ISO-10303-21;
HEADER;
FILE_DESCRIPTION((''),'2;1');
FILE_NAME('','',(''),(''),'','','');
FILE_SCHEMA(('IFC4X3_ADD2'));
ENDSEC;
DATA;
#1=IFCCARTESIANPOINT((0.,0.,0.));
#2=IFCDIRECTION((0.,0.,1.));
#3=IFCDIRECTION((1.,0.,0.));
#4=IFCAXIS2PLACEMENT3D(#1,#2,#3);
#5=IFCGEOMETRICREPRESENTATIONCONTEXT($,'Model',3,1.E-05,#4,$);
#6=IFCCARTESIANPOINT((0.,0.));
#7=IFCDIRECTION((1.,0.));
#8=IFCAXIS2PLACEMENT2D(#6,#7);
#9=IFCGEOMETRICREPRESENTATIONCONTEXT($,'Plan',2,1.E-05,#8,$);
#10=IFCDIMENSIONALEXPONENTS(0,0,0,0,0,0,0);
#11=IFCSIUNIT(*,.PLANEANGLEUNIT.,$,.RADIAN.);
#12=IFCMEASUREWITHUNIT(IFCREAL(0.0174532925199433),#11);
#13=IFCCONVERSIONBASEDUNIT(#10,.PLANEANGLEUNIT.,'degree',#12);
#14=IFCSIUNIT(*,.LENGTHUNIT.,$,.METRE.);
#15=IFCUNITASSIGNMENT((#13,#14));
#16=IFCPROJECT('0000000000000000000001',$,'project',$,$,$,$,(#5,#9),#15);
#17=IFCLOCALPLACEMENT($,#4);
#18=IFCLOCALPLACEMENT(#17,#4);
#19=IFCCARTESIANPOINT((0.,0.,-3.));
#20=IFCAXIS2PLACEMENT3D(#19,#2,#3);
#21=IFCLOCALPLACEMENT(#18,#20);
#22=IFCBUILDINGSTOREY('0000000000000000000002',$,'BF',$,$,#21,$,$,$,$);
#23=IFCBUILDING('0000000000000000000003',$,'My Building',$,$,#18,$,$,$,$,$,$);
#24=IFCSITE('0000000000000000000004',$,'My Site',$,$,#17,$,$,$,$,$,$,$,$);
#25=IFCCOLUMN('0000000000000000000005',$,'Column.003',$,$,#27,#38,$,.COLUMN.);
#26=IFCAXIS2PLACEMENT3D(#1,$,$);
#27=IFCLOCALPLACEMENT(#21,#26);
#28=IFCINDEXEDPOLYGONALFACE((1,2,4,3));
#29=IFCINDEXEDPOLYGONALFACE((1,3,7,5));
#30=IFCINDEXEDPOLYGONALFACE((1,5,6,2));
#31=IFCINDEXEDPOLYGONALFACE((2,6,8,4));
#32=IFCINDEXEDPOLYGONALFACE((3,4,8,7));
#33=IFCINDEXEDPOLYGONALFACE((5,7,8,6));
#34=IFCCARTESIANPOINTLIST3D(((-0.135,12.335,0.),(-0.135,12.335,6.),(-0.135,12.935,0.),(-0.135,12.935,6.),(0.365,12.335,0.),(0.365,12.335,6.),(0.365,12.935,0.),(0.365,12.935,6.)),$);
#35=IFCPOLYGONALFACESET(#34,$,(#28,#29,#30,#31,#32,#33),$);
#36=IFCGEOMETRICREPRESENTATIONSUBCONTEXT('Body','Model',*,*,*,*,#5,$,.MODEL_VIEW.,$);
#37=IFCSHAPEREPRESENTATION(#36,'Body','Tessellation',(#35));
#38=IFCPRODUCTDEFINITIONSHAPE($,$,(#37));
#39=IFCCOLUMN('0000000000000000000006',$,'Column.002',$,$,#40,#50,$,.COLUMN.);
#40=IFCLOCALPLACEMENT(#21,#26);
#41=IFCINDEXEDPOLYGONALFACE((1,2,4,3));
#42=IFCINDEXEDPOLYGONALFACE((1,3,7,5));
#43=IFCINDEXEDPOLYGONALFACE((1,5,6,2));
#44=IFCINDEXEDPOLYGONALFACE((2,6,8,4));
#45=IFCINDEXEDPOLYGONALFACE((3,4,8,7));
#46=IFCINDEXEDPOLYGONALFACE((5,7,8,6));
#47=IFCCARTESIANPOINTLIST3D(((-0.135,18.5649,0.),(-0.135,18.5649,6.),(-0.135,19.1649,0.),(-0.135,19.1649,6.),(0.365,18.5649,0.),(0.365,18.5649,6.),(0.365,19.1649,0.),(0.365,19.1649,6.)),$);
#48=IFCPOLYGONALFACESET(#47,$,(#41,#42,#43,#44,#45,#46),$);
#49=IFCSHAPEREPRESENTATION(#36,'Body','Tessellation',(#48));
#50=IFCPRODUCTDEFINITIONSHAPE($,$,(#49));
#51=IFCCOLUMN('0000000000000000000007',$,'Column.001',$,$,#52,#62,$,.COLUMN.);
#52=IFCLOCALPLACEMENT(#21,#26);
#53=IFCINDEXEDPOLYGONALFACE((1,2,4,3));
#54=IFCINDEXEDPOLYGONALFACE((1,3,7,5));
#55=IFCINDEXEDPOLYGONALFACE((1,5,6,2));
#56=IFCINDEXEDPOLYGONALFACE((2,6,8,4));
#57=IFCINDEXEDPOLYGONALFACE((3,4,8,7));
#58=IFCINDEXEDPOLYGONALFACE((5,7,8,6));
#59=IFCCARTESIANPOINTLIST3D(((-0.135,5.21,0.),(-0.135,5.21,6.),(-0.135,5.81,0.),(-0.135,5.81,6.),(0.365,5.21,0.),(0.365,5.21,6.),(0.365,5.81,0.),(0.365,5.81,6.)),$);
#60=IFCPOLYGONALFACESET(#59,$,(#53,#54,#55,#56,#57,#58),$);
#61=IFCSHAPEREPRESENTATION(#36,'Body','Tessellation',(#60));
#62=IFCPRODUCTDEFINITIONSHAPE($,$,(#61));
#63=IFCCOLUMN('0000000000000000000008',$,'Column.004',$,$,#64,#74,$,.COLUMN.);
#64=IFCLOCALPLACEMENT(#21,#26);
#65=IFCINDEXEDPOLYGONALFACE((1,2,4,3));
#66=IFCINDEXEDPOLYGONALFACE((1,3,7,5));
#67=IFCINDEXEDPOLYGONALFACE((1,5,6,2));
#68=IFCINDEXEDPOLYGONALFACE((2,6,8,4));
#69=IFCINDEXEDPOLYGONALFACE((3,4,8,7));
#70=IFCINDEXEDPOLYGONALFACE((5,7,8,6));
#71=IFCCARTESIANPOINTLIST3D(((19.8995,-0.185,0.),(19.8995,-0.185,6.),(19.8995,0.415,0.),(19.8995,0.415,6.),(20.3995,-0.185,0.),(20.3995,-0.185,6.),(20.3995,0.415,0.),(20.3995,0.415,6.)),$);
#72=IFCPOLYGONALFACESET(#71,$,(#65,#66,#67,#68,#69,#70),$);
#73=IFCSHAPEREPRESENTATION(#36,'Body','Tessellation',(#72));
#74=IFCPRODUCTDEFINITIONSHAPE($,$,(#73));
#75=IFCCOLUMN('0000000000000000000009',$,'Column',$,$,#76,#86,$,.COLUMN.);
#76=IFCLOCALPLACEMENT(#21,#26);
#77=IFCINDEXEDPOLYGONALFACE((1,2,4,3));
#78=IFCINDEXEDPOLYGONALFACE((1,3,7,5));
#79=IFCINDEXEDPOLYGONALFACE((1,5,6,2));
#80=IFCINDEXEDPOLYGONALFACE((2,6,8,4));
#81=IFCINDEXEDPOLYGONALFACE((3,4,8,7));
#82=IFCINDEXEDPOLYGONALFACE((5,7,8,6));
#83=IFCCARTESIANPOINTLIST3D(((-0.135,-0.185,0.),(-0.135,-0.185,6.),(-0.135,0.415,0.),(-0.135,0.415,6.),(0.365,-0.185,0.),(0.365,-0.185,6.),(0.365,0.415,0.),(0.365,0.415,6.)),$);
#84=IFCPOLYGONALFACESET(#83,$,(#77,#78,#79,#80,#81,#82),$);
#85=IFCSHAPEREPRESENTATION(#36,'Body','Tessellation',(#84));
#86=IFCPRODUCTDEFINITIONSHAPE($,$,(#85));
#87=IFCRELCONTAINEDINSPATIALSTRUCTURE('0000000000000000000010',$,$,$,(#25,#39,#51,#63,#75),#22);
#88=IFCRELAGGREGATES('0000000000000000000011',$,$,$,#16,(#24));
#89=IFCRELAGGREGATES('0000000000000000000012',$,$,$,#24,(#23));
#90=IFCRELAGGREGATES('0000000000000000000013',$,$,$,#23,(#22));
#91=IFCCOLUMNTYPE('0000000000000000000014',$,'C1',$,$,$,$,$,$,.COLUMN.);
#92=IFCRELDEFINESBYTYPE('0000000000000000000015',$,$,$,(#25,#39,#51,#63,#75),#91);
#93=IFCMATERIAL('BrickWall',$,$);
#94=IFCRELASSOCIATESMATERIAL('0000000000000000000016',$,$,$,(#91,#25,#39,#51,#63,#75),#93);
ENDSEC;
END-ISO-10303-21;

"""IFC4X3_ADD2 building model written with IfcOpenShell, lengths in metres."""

from ifc_helpers import new_model, entity, si_unit, converted_unit, frame, origin_with_axes, origin_2d_with_axis, place, context, subcontext, project, spatial, rectangle, extrude, material, material_profile, profile_set, profile_usage, type_object, element, save


model = new_model("IFC4X3_ADD2")

# Units and contexts
model_context = context("Model", 3, precision=1e-05, world=origin_with_axes())
plan_context = context("Plan", 2, precision=1e-05, world=origin_2d_with_axis())
body_context = subcontext(model_context, "Body", "Model", "MODEL_VIEW")
ifc_project = project(units=[converted_unit("PLANEANGLEUNIT", "degree", entity("IfcReal", 0.0174532925199433), si_unit("PLANEANGLEUNIT", "RADIAN"), dimensions=[0, 0, 0, 0, 0, 0, 0]), si_unit("LENGTHUNIT", "METRE")], contexts=[model_context, plan_context])

# Site, building, storey
site_placement = place(None, origin_with_axes())
site = spatial("IfcSite", under=ifc_project, at=site_placement, Name="My Site")
building_placement = place(site_placement, origin_with_axes())
building = spatial("IfcBuilding", under=site, at=building_placement, Name="My Building")
storey_placement = place(building_placement, frame((0.0, 0.0, -3.0), z_axis=(0.0, 0.0, 1.0), x_axis=(1.0, 0.0, 0.0)))
storey = spatial("IfcBuildingStorey", under=building, at=storey_placement, Name="BF")

# Columns
ifc_material = material(Name="BrickWall")
ifc_material_profile = material_profile(ifc_material, rectangle(XDim=0.5, YDim=0.6))
ifc_profile_set = profile_set([ifc_material_profile])
ifc_profile_usage_1 = profile_usage(ifc_profile_set, cardinal=5)
column_type = type_object("IfcColumnType", Name="C1", PredefinedType="COLUMN", material=ifc_profile_set)
column_1_placement = place(storey_placement, frame((0.115, 12.635, 0.0), z_axis=(0.0, 0.0, 1.0), x_axis=(1.0, 0.0, 0.0)))
element("IfcColumn", 1, at=column_1_placement, inside=storey, type_object=column_type, material=ifc_profile_usage_1, Name="Column.003", PredefinedType="COLUMN", context=body_context, shape_type="SweptSolid", body=[
    extrude(rectangle(XDim=0.5, YDim=0.6), origin_with_axes(), (0.0, 0.0, 1.0), 6.0),
])
ifc_profile_usage_2 = profile_usage(ifc_profile_set, cardinal=5)
column_2_placement = place(storey_placement, frame((0.115, 18.8649, 0.0), z_axis=(0.0, 0.0, 1.0), x_axis=(1.0, 0.0, 0.0)))
element("IfcColumn", 2, at=column_2_placement, inside=storey, type_object=column_type, material=ifc_profile_usage_2, Name="Column.002", PredefinedType="COLUMN", context=body_context, shape_type="SweptSolid", body=[
    extrude(rectangle(XDim=0.5, YDim=0.6), origin_with_axes(), (0.0, 0.0, 1.0), 6.0),
])
ifc_profile_usage_3 = profile_usage(ifc_profile_set, cardinal=5)
column_3_placement = place(storey_placement, frame((0.115, 5.51, 0.0), z_axis=(0.0, 0.0, 1.0), x_axis=(1.0, 0.0, 0.0)))
element("IfcColumn", 3, at=column_3_placement, inside=storey, type_object=column_type, material=ifc_profile_usage_3, Name="Column.001", PredefinedType="COLUMN", context=body_context, shape_type="SweptSolid", body=[
    extrude(rectangle(XDim=0.5, YDim=0.6), origin_with_axes(), (0.0, 0.0, 1.0), 6.0),
])
ifc_profile_usage_4 = profile_usage(ifc_profile_set, cardinal=5)
column_4_placement = place(storey_placement, frame((20.1495, 0.115, 0.0), z_axis=(0.0, 0.0, 1.0), x_axis=(1.0, 0.0, 0.0)))
element("IfcColumn", 4, at=column_4_placement, inside=storey, type_object=column_type, material=ifc_profile_usage_4, Name="Column.004", PredefinedType="COLUMN", context=body_context, shape_type="SweptSolid", body=[
    extrude(rectangle(XDim=0.5, YDim=0.6), origin_with_axes(), (0.0, 0.0, 1.0), 6.0),
])
ifc_profile_usage_5 = profile_usage(ifc_profile_set, cardinal=5)
column_5_placement = place(storey_placement, frame((0.115, 0.115, 0.0), z_axis=(0.0, 0.0, 1.0), x_axis=(1.0, 0.0, 0.0)))
element("IfcColumn", 5, at=column_5_placement, inside=storey, type_object=column_type, material=ifc_profile_usage_5, Name="Column", PredefinedType="COLUMN", context=body_context, shape_type="SweptSolid", body=[
    extrude(rectangle(XDim=0.5, YDim=0.6), origin_with_axes(), (0.0, 0.0, 1.0), 6.0),
])

save(model, "model.ifc")
